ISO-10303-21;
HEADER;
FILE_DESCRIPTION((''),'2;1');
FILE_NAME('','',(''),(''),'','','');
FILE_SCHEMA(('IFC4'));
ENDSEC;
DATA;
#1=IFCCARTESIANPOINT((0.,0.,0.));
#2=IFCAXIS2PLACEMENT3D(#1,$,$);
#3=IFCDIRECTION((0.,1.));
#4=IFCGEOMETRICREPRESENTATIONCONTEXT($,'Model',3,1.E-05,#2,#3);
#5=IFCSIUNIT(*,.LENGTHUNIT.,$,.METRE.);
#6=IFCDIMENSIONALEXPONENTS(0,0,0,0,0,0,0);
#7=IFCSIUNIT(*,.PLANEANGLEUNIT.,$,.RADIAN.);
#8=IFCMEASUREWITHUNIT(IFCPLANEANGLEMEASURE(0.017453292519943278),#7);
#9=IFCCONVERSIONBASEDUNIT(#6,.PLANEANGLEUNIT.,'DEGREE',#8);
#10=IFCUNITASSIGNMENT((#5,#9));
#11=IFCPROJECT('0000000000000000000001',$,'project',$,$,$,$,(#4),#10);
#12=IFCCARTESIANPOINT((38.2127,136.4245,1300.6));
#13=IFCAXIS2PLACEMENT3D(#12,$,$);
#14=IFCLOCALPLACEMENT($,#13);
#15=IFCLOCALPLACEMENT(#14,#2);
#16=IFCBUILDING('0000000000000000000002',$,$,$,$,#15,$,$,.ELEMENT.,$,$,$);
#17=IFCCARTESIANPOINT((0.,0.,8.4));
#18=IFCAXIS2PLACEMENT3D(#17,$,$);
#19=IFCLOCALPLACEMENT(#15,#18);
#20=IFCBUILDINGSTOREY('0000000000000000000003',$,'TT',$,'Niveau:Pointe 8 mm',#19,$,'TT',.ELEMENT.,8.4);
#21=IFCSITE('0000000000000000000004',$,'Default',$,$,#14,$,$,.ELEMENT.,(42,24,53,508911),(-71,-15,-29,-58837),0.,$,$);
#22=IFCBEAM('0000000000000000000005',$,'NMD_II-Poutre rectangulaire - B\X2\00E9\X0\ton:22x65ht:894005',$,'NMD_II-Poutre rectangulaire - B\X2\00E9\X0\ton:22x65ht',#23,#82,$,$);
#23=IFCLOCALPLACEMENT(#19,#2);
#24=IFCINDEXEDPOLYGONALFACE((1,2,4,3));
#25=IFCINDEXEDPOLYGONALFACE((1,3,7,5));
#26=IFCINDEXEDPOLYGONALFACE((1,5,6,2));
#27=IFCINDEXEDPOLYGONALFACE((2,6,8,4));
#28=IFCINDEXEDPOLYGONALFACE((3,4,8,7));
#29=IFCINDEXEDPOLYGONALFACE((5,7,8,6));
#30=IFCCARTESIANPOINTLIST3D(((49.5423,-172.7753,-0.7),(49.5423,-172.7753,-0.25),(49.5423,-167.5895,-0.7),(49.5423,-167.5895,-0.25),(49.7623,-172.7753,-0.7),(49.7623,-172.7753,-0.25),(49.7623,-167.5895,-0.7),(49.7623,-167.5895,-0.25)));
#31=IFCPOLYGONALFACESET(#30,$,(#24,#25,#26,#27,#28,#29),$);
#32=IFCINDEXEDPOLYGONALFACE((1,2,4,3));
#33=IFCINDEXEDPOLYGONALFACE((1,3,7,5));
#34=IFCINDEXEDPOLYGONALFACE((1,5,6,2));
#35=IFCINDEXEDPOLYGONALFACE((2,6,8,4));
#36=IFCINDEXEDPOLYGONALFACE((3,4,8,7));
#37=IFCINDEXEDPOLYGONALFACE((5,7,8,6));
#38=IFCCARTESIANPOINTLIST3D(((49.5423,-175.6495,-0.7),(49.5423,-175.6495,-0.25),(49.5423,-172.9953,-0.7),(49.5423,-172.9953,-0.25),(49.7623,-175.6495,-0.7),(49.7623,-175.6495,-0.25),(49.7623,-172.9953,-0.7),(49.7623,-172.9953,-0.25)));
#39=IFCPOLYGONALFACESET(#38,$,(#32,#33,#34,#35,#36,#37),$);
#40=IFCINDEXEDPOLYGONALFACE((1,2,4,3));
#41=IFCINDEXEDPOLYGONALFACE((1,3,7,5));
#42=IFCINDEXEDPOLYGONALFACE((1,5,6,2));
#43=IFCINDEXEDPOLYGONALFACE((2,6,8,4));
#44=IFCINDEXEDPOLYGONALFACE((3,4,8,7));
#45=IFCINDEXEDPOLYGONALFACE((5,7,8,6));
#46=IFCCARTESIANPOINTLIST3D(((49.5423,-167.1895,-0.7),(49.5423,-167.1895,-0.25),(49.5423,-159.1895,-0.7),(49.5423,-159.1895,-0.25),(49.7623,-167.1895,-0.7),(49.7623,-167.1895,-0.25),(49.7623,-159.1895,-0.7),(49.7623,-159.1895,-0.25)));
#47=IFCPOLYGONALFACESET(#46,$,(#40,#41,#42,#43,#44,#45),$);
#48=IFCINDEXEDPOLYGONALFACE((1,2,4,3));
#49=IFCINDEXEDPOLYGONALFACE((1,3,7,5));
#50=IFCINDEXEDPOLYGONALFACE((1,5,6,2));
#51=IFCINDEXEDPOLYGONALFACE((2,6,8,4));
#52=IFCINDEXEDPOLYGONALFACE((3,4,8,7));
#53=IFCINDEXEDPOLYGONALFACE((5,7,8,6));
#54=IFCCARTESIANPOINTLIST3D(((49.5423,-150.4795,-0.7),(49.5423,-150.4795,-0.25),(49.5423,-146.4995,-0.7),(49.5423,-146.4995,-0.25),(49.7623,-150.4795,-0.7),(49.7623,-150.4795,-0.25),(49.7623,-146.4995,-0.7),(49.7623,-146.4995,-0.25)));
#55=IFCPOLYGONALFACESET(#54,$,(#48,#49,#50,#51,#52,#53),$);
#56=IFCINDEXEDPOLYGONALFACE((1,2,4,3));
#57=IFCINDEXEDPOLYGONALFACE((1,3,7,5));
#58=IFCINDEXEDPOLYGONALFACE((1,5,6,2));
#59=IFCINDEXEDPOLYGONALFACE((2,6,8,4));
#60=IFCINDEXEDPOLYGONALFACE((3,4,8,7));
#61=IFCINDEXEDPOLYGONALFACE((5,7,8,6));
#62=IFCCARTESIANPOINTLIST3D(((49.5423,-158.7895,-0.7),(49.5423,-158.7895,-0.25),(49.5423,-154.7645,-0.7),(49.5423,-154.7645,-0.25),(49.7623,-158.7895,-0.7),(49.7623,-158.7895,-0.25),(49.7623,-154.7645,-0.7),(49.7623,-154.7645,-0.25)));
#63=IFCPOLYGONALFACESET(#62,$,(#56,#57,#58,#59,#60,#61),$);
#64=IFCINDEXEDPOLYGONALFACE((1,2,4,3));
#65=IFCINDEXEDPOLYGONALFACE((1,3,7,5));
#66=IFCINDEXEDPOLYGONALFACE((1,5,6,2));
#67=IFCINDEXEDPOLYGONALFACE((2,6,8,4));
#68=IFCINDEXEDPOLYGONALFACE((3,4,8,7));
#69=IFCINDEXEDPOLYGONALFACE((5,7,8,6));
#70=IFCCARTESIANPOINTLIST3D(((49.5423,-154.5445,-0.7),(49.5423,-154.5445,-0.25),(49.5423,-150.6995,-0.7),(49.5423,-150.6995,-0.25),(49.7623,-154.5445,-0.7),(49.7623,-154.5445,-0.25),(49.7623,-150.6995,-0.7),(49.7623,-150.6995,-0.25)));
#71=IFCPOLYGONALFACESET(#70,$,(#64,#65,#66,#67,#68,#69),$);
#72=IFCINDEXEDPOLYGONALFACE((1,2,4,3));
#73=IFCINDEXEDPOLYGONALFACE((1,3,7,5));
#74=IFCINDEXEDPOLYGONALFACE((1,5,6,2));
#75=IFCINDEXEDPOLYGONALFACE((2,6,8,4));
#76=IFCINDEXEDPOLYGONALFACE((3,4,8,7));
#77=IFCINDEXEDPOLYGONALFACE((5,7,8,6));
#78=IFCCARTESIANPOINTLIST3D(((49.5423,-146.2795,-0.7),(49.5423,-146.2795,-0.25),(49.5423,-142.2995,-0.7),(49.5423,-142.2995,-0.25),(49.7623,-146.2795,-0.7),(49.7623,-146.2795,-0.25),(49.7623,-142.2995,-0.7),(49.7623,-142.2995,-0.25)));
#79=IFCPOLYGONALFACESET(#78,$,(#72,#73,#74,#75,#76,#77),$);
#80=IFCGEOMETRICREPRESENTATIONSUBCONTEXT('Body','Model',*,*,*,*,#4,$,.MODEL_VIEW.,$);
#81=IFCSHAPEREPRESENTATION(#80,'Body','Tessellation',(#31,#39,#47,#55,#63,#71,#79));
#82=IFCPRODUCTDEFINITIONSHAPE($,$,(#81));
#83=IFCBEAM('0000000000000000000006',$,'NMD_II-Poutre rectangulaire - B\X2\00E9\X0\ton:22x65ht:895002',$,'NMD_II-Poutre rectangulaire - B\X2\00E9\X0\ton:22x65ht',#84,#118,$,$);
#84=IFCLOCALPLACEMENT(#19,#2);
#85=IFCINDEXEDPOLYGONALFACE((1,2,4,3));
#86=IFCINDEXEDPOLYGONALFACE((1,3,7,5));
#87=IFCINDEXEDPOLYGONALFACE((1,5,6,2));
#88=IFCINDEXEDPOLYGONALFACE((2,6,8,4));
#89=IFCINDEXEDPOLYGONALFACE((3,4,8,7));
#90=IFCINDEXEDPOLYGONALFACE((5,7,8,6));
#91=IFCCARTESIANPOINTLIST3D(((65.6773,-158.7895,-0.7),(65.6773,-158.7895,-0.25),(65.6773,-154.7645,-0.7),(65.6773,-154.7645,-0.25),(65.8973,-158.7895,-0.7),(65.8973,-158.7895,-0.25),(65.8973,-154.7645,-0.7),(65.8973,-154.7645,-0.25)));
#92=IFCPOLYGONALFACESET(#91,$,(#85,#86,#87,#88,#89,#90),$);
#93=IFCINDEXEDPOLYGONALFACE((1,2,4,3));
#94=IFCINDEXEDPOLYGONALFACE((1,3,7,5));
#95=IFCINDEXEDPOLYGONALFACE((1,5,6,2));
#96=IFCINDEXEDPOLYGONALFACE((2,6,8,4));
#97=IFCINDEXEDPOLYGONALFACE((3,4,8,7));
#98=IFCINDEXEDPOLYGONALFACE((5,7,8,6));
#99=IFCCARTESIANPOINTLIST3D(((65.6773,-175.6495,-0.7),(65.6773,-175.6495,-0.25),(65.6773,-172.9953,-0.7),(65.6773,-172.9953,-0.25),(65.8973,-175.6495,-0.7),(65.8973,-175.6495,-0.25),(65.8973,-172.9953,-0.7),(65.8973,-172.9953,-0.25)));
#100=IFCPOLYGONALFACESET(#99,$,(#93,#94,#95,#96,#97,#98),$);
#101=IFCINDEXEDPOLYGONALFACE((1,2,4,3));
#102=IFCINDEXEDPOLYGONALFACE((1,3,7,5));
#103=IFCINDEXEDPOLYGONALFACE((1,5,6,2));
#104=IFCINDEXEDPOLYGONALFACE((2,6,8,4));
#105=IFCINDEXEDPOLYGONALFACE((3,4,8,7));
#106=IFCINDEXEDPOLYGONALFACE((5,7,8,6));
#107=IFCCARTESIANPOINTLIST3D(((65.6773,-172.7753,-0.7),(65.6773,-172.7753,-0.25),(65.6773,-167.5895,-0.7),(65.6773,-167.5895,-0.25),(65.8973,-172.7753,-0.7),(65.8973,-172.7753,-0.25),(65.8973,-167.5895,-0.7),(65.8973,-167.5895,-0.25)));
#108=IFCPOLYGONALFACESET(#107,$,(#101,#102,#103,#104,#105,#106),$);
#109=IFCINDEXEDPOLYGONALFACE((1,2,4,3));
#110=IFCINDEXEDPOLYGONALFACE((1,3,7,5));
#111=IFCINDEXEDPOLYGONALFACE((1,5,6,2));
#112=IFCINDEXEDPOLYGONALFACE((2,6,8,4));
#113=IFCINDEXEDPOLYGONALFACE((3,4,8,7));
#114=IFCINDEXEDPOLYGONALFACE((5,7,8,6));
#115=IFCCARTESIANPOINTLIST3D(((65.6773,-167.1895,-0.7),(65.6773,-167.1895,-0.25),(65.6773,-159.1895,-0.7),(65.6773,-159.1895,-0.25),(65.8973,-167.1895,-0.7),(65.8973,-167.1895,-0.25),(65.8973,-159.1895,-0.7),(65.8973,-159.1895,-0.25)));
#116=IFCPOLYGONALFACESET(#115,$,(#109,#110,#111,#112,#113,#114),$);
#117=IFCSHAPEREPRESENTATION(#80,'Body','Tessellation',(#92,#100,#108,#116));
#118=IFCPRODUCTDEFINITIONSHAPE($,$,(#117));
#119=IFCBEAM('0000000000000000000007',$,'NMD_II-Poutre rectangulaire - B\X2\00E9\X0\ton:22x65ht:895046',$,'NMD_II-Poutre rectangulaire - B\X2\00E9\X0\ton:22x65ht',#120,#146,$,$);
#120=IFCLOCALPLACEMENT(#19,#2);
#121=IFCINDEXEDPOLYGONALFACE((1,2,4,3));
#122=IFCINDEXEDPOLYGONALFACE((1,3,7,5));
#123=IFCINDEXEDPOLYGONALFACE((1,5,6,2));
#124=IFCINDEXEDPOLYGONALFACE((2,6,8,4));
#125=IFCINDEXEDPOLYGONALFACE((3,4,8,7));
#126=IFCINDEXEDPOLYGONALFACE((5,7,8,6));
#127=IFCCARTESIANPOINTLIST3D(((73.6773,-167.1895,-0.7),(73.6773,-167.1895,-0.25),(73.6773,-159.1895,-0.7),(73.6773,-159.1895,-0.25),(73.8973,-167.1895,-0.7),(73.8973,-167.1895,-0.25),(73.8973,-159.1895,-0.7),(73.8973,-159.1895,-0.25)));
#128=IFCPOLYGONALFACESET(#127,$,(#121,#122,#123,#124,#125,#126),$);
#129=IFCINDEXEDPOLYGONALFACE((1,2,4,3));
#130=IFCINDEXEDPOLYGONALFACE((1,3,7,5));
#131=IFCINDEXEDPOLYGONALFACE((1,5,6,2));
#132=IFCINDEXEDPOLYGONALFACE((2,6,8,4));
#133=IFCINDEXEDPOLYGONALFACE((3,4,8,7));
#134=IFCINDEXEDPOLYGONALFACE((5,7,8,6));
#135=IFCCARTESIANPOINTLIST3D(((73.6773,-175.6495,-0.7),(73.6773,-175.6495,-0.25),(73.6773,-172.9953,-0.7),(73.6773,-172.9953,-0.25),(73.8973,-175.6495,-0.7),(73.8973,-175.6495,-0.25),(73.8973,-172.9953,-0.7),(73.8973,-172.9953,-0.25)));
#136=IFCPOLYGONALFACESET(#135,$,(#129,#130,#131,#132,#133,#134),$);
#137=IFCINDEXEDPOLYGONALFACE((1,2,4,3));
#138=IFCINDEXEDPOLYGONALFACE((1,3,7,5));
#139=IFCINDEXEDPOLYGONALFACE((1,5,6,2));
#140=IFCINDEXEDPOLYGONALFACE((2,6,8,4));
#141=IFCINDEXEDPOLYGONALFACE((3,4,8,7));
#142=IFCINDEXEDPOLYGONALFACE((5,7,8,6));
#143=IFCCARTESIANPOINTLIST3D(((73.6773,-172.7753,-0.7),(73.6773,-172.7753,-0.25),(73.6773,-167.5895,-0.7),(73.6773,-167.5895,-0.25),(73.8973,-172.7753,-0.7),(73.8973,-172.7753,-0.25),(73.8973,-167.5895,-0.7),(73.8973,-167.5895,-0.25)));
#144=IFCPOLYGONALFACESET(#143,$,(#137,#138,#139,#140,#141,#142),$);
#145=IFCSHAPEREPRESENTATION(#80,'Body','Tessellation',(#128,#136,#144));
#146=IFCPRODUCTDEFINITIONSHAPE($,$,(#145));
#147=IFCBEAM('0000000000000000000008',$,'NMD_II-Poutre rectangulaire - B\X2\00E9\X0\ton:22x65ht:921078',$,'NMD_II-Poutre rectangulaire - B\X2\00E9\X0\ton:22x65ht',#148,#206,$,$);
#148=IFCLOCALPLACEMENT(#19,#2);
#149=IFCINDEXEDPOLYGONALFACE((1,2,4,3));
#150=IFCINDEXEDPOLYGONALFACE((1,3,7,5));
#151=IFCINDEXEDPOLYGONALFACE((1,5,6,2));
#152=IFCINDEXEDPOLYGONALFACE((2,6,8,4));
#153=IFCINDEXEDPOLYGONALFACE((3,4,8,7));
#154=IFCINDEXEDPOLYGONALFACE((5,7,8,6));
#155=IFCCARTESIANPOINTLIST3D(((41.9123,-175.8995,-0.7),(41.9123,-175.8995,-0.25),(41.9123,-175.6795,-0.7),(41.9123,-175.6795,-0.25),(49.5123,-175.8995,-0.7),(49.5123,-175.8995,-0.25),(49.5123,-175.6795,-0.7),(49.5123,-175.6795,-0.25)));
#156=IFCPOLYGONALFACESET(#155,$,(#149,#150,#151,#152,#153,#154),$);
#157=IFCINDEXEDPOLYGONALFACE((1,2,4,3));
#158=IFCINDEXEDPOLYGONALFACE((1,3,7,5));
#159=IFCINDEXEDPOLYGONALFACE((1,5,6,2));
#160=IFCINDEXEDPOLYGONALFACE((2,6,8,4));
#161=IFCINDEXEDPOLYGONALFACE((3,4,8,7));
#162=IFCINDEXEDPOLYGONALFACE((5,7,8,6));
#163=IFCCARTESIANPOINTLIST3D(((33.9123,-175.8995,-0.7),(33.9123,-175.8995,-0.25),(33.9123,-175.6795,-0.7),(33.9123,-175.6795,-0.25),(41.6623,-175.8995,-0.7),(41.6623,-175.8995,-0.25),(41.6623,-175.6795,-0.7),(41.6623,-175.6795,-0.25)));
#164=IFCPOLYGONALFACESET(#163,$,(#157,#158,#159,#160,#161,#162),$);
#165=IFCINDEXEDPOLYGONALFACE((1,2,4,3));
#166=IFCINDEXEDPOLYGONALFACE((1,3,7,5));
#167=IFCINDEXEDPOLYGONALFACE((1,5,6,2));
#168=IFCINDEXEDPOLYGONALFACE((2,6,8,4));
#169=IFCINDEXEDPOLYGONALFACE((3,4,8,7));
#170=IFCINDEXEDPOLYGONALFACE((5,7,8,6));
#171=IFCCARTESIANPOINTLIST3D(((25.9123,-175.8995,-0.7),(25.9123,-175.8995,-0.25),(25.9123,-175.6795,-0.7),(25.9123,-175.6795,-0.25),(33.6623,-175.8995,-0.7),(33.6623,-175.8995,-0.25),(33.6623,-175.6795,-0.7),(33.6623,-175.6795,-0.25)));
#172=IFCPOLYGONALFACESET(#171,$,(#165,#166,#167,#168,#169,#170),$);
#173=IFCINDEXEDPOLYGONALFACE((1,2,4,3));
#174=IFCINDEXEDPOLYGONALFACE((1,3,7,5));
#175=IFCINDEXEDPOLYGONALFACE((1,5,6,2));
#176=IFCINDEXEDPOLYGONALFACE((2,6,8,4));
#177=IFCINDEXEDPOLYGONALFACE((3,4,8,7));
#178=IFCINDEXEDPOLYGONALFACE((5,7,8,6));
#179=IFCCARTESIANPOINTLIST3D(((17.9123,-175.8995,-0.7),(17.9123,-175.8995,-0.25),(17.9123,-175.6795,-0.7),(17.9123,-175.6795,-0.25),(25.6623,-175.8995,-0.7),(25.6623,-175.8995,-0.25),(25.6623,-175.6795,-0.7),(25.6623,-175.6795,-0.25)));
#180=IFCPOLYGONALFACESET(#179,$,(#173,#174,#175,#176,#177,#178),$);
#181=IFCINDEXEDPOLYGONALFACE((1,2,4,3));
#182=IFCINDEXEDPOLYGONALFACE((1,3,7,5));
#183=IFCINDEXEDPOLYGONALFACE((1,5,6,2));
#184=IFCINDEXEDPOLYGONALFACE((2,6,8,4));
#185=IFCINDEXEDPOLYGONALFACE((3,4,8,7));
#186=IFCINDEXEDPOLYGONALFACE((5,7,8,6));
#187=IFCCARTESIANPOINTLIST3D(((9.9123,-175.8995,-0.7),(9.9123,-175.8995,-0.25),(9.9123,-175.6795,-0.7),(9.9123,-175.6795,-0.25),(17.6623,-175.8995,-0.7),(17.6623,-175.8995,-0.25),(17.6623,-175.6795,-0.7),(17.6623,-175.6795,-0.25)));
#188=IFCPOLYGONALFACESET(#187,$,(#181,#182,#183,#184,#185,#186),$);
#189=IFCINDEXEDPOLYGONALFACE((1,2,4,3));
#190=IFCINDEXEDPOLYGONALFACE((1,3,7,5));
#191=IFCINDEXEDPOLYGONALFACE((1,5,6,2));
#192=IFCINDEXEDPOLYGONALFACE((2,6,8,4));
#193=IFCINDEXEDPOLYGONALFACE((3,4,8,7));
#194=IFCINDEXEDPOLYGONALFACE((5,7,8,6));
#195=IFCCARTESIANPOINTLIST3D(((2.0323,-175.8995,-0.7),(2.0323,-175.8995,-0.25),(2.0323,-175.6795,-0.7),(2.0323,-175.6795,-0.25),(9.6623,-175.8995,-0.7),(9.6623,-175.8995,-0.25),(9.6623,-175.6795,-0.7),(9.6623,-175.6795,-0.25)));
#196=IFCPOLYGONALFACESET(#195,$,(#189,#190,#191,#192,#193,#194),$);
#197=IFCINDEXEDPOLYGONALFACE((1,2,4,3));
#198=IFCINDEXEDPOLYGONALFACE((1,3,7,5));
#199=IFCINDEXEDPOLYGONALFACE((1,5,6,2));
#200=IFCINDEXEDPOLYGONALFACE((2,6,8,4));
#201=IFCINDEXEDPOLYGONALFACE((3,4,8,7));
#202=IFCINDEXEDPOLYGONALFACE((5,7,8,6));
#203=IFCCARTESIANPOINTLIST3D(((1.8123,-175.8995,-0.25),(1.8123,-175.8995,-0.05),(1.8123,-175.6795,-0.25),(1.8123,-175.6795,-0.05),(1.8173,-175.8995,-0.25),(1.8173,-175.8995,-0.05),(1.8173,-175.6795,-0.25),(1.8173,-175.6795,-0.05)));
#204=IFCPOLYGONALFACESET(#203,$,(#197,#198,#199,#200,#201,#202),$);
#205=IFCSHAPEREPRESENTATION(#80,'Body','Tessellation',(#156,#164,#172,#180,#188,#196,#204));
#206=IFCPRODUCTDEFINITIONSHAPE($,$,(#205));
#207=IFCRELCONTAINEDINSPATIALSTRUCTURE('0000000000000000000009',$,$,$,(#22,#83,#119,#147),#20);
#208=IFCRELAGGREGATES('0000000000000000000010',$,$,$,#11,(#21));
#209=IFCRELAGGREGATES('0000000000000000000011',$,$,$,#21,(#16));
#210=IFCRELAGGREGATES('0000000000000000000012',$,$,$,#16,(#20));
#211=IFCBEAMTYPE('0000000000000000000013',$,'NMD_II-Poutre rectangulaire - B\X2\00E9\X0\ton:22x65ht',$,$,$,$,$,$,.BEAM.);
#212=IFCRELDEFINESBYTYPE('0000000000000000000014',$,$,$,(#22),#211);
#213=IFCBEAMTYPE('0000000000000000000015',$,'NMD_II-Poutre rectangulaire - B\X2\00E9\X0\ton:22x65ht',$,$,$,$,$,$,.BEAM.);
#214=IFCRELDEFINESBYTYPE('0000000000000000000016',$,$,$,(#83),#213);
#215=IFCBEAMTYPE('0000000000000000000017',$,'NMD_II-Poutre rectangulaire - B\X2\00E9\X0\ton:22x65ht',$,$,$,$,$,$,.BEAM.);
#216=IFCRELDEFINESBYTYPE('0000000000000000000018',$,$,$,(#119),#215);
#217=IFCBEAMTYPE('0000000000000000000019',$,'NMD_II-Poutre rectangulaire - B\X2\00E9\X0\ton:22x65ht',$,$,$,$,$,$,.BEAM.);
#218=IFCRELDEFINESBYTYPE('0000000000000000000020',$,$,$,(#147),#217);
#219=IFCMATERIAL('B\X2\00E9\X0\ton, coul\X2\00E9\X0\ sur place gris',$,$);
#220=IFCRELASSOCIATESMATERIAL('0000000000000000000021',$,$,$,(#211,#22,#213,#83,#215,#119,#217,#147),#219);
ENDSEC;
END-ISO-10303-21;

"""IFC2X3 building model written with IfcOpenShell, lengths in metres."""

from ifc_helpers import new_model, entity, si_unit, converted_unit, direction, frame, frame_2d, origin, place, context, subcontext, project, spatial, rectangle, extrude, source, transform, mapped, material, type_object, type_shapes, element, save


model = new_model("IFC2X3")

# Units and contexts
model_context = context("Model", 3, precision=1e-05, world=origin(), true_north=direction((0.0, 1.0)))
body_context = subcontext(model_context, "Body", "Model", "MODEL_VIEW")
ifc_project = project(units=[si_unit("LENGTHUNIT", "METRE"), converted_unit("PLANEANGLEUNIT", "DEGREE", entity("IfcPlaneAngleMeasure", 0.017453292519943278), si_unit("PLANEANGLEUNIT", "RADIAN"), dimensions=[0, 0, 0, 0, 0, 0, 0])], contexts=[model_context])

# Site, building, storey
site_placement = place(None, frame((38.2127, 136.4245, 1300.6)))
site = spatial("IfcSite", under=ifc_project, at=site_placement, Name="Default", CompositionType="ELEMENT", RefLatitude=(42, 24, 53, 508911), RefLongitude=(-71, -15, -29, -58837), RefElevation=0.0)
building_placement = place(site_placement, origin())
building = spatial("IfcBuilding", under=site, at=building_placement, CompositionType="ELEMENT")
storey_placement = place(building_placement, frame((0.0, 0.0, 8.4)))
storey = spatial("IfcBuildingStorey", under=building, at=storey_placement, Name="TT", ObjectType="Niveau:Pointe 8 mm", LongName="TT", CompositionType="ELEMENT", Elevation=8.4)

# Beams
ifc_material_1 = material(Name="Béton, coulé sur place gris")
beam_type_1 = type_object("IfcBeamType", Name="NMD_II-Poutre rectangulaire - Béton:22x65ht", PredefinedType="BEAM", material=ifc_material_1)
shared_shape_1 = source(origin(), body_context, "Body", "SweptSolid", [
    extrude(rectangle(XDim=0.45, YDim=0.22, at=frame_2d((0.0, 0.0), x_axis=(0.0, 1.0))), frame((49.6523, -172.7753, 7.925), z_axis=(0.0, 1.0, 0.0), x_axis=(-1.0, 0.0, 0.0)), (0.0, 0.0, 1.0), 5.1859),
    extrude(rectangle(XDim=0.45, YDim=0.22, at=frame_2d((0.0, 0.0), x_axis=(0.0, 1.0))), frame((49.6523, -175.6495, 7.925), z_axis=(0.0, 1.0, 0.0), x_axis=(-1.0, 0.0, 0.0)), (0.0, 0.0, 1.0), 2.6541),
    extrude(rectangle(XDim=0.45, YDim=0.22, at=frame_2d((0.0, 0.0), x_axis=(0.0, 1.0))), frame((49.6523, -167.1895, 7.925), z_axis=(0.0, 1.0, 0.0), x_axis=(-1.0, 0.0, 0.0)), (0.0, 0.0, 1.0), 8.0),
    extrude(rectangle(XDim=0.45, YDim=0.22, at=frame_2d((0.0, 0.0), x_axis=(0.0, 1.0))), frame((49.6523, -150.4795, 7.925), z_axis=(0.0, 1.0, 0.0), x_axis=(-1.0, 0.0, 0.0)), (0.0, 0.0, 1.0), 3.98),
    extrude(rectangle(XDim=0.45, YDim=0.22, at=frame_2d((0.0, 0.0), x_axis=(0.0, 1.0))), frame((49.6523, -158.7895, 7.925), z_axis=(0.0, 1.0, 0.0), x_axis=(-1.0, 0.0, 0.0)), (0.0, 0.0, 1.0), 4.025),
    extrude(rectangle(XDim=0.45, YDim=0.22, at=frame_2d((0.0, 0.0), x_axis=(0.0, 1.0))), frame((49.6523, -154.5445, 7.925), z_axis=(0.0, 1.0, 0.0), x_axis=(-1.0, 0.0, 0.0)), (0.0, 0.0, 1.0), 3.845),
    extrude(rectangle(XDim=0.45, YDim=0.22, at=frame_2d((0.0, 0.0), x_axis=(0.0, 1.0))), frame((49.6523, -146.2795, 7.925), z_axis=(0.0, 1.0, 0.0), x_axis=(-1.0, 0.0, 0.0)), (0.0, 0.0, 1.0), 3.98),
])
type_shapes(beam_type_1, [shared_shape_1])
beam_1_placement = place(storey_placement, frame((0.0, 0.0, -8.4)))
element("IfcBeam", 1, at=beam_1_placement, inside=storey, type_object=beam_type_1, material=ifc_material_1, Name="NMD_II-Poutre rectangulaire - Béton:22x65ht:894005", ObjectType="NMD_II-Poutre rectangulaire - Béton:22x65ht", context=body_context, shape_type="MappedRepresentation", body=[
    mapped(shared_shape_1, transform((0.0, 0.0, 0.0), scale=1.0)),
])
beam_type_2 = type_object("IfcBeamType", Name="NMD_II-Poutre rectangulaire - Béton:22x65ht", PredefinedType="BEAM", material=ifc_material_1)
shared_shape_2 = source(origin(), body_context, "Body", "SweptSolid", [
    extrude(rectangle(XDim=0.45, YDim=0.22, at=frame_2d((0.0, 0.0), x_axis=(0.0, 1.0))), frame((65.7873, -158.7895, 7.925), z_axis=(0.0, 1.0, 0.0), x_axis=(-1.0, 0.0, 0.0)), (0.0, 0.0, 1.0), 4.025),
    extrude(rectangle(XDim=0.45, YDim=0.22, at=frame_2d((0.0, 0.0), x_axis=(0.0, 1.0))), frame((65.7873, -175.6495, 7.925), z_axis=(0.0, 1.0, 0.0), x_axis=(-1.0, 0.0, 0.0)), (0.0, 0.0, 1.0), 2.6541),
    extrude(rectangle(XDim=0.45, YDim=0.22, at=frame_2d((0.0, 0.0), x_axis=(0.0, 1.0))), frame((65.7873, -172.7753, 7.925), z_axis=(0.0, 1.0, 0.0), x_axis=(-1.0, 0.0, 0.0)), (0.0, 0.0, 1.0), 5.1859),
    extrude(rectangle(XDim=0.45, YDim=0.22, at=frame_2d((0.0, 0.0), x_axis=(0.0, 1.0))), frame((65.7873, -167.1895, 7.925), z_axis=(0.0, 1.0, 0.0), x_axis=(-1.0, 0.0, 0.0)), (0.0, 0.0, 1.0), 8.0),
])
type_shapes(beam_type_2, [shared_shape_2])
beam_2_placement = place(storey_placement, frame((0.0, 0.0, -8.4)))
element("IfcBeam", 2, at=beam_2_placement, inside=storey, type_object=beam_type_2, material=ifc_material_1, Name="NMD_II-Poutre rectangulaire - Béton:22x65ht:895002", ObjectType="NMD_II-Poutre rectangulaire - Béton:22x65ht", context=body_context, shape_type="MappedRepresentation", body=[
    mapped(shared_shape_2, transform((0.0, 0.0, 0.0), scale=1.0)),
])
beam_type_3 = type_object("IfcBeamType", Name="NMD_II-Poutre rectangulaire - Béton:22x65ht", PredefinedType="BEAM", material=ifc_material_1)
shared_shape_3 = source(origin(), body_context, "Body", "SweptSolid", [
    extrude(rectangle(XDim=0.45, YDim=0.22, at=frame_2d((0.0, 0.0), x_axis=(0.0, 1.0))), frame((73.7873, -167.1895, 7.925), z_axis=(0.0, 1.0, 0.0), x_axis=(-1.0, 0.0, 0.0)), (0.0, 0.0, 1.0), 8.0),
    extrude(rectangle(XDim=0.45, YDim=0.22, at=frame_2d((0.0, 0.0), x_axis=(0.0, 1.0))), frame((73.7873, -175.6495, 7.925), z_axis=(0.0, 1.0, 0.0), x_axis=(-1.0, 0.0, 0.0)), (0.0, 0.0, 1.0), 2.6541),
    extrude(rectangle(XDim=0.45, YDim=0.22, at=frame_2d((0.0, 0.0), x_axis=(0.0, 1.0))), frame((73.7873, -172.7753, 7.925), z_axis=(0.0, 1.0, 0.0), x_axis=(-1.0, 0.0, 0.0)), (0.0, 0.0, 1.0), 5.1859),
])
type_shapes(beam_type_3, [shared_shape_3])
beam_3_placement = place(storey_placement, frame((0.0, 0.0, -8.4)))
element("IfcBeam", 3, at=beam_3_placement, inside=storey, type_object=beam_type_3, material=ifc_material_1, Name="NMD_II-Poutre rectangulaire - Béton:22x65ht:895046", ObjectType="NMD_II-Poutre rectangulaire - Béton:22x65ht", context=body_context, shape_type="MappedRepresentation", body=[
    mapped(shared_shape_3, transform((0.0, 0.0, 0.0), scale=1.0)),
])
beam_type_4 = type_object("IfcBeamType", Name="NMD_II-Poutre rectangulaire - Béton:22x65ht", PredefinedType="BEAM", material=ifc_material_1)
shared_shape_4 = source(origin(), body_context, "Body", "SweptSolid", [
    extrude(rectangle(XDim=0.45, YDim=0.22, at=frame_2d((0.0, 0.0), x_axis=(1.0, 0.0))), frame((41.9123, -175.7895, 7.925), z_axis=(1.0, 0.0, 0.0), x_axis=(0.0, 0.0, -1.0)), (0.0, 0.0, 1.0), 7.6),
    extrude(rectangle(XDim=0.45, YDim=0.22, at=frame_2d((0.0, 0.0), x_axis=(1.0, 0.0))), frame((33.9123, -175.7895, 7.925), z_axis=(1.0, 0.0, 0.0), x_axis=(0.0, 0.0, -1.0)), (0.0, 0.0, 1.0), 7.75),
    extrude(rectangle(XDim=0.45, YDim=0.22, at=frame_2d((0.0, 0.0), x_axis=(1.0, 0.0))), frame((25.9123, -175.7895, 7.925), z_axis=(1.0, 0.0, 0.0), x_axis=(0.0, 0.0, -1.0)), (0.0, 0.0, 1.0), 7.75),
    extrude(rectangle(XDim=0.45, YDim=0.22, at=frame_2d((0.0, 0.0), x_axis=(1.0, 0.0))), frame((17.9123, -175.7895, 7.925), z_axis=(1.0, 0.0, 0.0), x_axis=(0.0, 0.0, -1.0)), (0.0, 0.0, 1.0), 7.75),
    extrude(rectangle(XDim=0.45, YDim=0.22, at=frame_2d((0.0, 0.0), x_axis=(1.0, 0.0))), frame((9.9123, -175.7895, 7.925), z_axis=(1.0, 0.0, 0.0), x_axis=(0.0, 0.0, -1.0)), (0.0, 0.0, 1.0), 7.75),
    extrude(rectangle(XDim=0.45, YDim=0.22, at=frame_2d((0.0, 0.0), x_axis=(1.0, 0.0))), frame((2.0323, -175.7895, 7.925), z_axis=(1.0, 0.0, 0.0), x_axis=(0.0, 0.0, -1.0)), (0.0, 0.0, 1.0), 7.63),
    extrude(rectangle(XDim=0.2, YDim=0.22, at=frame_2d((0.0, 0.0), x_axis=(1.0, 0.0))), frame((1.8123, -175.7895, 8.25), z_axis=(1.0, 0.0, 0.0), x_axis=(0.0, 0.0, -1.0)), (0.0, 0.0, 1.0), 0.005),
])
type_shapes(beam_type_4, [shared_shape_4])
beam_4_placement = place(storey_placement, frame((0.0, 0.0, -8.4)))
element("IfcBeam", 4, at=beam_4_placement, inside=storey, type_object=beam_type_4, material=ifc_material_1, Name="NMD_II-Poutre rectangulaire - Béton:22x65ht:921078", ObjectType="NMD_II-Poutre rectangulaire - Béton:22x65ht", context=body_context, shape_type="MappedRepresentation", body=[
    mapped(shared_shape_4, transform((0.0, 0.0, 0.0), scale=1.0)),
])

save(model, "model.ifc")
